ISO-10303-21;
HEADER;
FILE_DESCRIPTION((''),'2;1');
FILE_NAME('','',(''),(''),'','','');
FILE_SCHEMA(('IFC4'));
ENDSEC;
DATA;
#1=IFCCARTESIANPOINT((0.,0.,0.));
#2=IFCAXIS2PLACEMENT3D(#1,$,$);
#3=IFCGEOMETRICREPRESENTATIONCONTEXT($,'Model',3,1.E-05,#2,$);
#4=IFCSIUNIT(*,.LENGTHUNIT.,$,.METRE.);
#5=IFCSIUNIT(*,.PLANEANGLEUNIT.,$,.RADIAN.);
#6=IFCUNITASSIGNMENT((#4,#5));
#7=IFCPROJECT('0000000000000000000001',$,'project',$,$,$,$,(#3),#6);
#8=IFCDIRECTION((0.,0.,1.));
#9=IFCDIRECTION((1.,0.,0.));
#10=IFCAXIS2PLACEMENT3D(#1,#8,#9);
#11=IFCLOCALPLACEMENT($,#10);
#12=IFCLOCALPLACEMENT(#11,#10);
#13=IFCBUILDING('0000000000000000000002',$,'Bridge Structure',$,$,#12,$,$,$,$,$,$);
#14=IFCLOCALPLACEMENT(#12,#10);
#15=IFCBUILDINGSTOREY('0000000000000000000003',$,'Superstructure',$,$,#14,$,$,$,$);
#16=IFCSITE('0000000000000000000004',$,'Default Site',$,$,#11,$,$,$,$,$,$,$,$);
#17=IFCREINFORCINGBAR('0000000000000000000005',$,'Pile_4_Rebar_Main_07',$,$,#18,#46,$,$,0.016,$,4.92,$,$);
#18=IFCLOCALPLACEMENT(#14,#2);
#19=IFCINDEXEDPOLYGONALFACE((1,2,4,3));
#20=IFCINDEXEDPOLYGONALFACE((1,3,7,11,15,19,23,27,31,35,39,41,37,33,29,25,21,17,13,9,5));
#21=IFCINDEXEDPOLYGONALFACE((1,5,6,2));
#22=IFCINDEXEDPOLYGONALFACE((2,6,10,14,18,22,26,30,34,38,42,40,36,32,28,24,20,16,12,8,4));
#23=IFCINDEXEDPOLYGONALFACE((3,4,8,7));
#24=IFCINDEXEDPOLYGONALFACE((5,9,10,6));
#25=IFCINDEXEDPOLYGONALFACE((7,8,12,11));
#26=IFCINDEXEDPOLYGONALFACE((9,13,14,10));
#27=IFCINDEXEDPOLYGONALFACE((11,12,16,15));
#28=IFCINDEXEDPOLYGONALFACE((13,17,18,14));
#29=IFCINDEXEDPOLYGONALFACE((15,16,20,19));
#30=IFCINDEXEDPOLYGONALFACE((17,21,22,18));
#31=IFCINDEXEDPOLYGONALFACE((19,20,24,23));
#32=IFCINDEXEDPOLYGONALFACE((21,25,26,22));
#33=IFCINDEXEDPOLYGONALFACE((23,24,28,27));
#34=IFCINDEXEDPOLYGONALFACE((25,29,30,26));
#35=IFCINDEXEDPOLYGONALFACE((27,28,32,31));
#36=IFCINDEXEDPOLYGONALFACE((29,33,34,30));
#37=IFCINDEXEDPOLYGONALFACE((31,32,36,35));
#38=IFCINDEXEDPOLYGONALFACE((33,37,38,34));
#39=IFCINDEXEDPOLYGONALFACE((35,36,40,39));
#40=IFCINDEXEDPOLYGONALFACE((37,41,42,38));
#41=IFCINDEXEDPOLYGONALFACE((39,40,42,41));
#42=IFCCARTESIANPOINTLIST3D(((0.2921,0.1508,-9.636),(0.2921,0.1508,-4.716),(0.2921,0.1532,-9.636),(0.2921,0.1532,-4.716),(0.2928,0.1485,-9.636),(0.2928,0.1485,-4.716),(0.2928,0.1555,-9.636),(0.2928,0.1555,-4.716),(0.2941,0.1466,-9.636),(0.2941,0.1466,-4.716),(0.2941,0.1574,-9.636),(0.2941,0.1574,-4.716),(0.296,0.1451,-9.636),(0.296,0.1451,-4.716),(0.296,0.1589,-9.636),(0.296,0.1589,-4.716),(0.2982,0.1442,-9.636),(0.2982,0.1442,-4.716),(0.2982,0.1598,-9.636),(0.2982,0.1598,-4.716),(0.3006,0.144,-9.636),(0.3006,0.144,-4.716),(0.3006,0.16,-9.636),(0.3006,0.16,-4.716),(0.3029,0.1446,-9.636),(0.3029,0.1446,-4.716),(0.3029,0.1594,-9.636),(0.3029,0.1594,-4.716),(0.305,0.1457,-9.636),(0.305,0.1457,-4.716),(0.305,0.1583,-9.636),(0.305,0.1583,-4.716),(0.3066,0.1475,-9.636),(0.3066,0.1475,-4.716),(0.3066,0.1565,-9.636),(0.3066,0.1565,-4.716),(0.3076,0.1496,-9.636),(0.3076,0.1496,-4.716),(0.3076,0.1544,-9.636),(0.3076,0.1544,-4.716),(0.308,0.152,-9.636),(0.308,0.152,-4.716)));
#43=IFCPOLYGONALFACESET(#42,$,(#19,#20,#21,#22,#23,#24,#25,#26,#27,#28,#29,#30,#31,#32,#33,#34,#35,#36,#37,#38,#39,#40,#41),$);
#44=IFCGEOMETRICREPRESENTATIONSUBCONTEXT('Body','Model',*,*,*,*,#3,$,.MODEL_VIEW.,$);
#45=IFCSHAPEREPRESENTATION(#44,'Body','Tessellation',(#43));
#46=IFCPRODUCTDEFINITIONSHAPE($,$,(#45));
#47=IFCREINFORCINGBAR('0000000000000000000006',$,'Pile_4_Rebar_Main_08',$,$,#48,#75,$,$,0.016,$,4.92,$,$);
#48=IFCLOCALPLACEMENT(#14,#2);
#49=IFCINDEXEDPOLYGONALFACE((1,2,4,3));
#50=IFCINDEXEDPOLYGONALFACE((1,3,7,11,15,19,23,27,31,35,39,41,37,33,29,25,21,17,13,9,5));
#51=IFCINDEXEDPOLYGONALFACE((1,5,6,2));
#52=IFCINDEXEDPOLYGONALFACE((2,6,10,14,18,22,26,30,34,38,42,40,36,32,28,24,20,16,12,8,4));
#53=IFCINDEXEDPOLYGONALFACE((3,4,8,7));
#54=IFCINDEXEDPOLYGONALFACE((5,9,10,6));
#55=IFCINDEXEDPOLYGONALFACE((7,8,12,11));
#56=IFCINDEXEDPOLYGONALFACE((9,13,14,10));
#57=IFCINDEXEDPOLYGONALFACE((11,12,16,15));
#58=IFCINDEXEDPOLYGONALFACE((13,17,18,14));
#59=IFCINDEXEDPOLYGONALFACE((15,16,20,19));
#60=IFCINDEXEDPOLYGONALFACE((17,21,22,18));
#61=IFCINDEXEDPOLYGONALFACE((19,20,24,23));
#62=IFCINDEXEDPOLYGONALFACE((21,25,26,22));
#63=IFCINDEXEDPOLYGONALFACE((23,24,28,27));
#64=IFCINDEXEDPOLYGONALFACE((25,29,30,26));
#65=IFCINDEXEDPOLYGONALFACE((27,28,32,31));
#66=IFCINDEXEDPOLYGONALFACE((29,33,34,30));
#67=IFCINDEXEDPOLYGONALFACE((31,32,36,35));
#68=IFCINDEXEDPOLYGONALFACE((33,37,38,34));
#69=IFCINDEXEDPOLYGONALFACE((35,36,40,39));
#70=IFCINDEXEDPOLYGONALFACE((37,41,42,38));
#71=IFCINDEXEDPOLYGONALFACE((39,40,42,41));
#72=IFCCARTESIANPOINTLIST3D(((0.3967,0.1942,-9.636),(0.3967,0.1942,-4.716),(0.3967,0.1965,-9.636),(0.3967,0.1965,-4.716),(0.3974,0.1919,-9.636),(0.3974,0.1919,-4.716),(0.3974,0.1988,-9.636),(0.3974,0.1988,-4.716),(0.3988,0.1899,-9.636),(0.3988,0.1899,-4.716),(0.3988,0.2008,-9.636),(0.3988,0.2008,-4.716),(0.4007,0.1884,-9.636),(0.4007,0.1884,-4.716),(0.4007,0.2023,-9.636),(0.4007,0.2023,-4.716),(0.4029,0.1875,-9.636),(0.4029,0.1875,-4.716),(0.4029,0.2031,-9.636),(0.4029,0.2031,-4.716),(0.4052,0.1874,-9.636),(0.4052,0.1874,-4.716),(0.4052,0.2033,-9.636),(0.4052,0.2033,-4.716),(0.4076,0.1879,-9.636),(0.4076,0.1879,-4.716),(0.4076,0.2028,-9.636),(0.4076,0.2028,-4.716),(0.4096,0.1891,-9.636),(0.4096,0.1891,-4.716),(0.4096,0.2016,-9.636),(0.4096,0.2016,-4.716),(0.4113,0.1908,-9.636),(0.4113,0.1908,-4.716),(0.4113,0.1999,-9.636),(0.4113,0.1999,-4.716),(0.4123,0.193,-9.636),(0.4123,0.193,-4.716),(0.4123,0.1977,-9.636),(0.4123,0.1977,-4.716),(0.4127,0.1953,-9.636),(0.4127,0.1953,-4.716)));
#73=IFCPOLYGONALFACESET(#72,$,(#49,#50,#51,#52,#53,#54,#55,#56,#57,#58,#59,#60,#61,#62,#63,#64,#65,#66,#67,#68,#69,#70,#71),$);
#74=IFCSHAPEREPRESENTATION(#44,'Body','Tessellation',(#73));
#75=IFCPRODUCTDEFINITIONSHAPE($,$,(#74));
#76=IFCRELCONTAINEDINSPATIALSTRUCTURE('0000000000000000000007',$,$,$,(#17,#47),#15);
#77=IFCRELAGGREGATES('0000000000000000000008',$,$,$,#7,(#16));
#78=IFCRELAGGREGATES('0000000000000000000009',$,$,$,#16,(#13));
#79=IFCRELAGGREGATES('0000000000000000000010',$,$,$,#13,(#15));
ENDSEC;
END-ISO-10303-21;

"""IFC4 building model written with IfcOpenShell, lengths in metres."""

from ifc_helpers import new_model, si_unit, frame, origin, origin_with_axes, origin_2d_with_axis, place, context, subcontext, project, spatial, circle, extrude, element, save


model = new_model("IFC4")

# Units and contexts
model_context = context("Model", 3, precision=1e-05, world=origin())
body_context = subcontext(model_context, "Body", "Model", "MODEL_VIEW")
ifc_project = project(units=[si_unit("LENGTHUNIT", "METRE"), si_unit("PLANEANGLEUNIT", "RADIAN")], contexts=[model_context])

# Site, building, storey
site_placement = place(None, origin_with_axes())
site = spatial("IfcSite", under=ifc_project, at=site_placement, Name="Default Site")
building_placement = place(site_placement, origin_with_axes())
building = spatial("IfcBuilding", under=site, at=building_placement, Name="Bridge Structure")
storey_placement = place(building_placement, origin_with_axes())
storey = spatial("IfcBuildingStorey", under=building, at=storey_placement, Name="Superstructure")

# Reinforcing bars
for number, where, z_axis, x_axis, name in (
    (1, (0.3, 0.152, -9.636), (0.0, 0.0, 1.0), (1.0, 0.0, 0.0), "Pile_4_Rebar_Main_07"),
    (2, (0.4047, 0.1953, -9.636), (0.0, 0.0, 1.0), (1.0, 0.0, 0.0), "Pile_4_Rebar_Main_08"),
):
    element("IfcReinforcingBar", number, at=place(storey_placement, frame(where, z_axis=z_axis, x_axis=x_axis)), inside=storey, Name=name, BarLength=4.92, NominalDiameter=0.016, context=body_context, shape_type="SweptSolid", body=[
        extrude(circle(Radius=0.008, at=origin_2d_with_axis()), origin_with_axes(), (0.0, 0.0, 1.0), 4.92),
    ])

save(model, "model.ifc")
